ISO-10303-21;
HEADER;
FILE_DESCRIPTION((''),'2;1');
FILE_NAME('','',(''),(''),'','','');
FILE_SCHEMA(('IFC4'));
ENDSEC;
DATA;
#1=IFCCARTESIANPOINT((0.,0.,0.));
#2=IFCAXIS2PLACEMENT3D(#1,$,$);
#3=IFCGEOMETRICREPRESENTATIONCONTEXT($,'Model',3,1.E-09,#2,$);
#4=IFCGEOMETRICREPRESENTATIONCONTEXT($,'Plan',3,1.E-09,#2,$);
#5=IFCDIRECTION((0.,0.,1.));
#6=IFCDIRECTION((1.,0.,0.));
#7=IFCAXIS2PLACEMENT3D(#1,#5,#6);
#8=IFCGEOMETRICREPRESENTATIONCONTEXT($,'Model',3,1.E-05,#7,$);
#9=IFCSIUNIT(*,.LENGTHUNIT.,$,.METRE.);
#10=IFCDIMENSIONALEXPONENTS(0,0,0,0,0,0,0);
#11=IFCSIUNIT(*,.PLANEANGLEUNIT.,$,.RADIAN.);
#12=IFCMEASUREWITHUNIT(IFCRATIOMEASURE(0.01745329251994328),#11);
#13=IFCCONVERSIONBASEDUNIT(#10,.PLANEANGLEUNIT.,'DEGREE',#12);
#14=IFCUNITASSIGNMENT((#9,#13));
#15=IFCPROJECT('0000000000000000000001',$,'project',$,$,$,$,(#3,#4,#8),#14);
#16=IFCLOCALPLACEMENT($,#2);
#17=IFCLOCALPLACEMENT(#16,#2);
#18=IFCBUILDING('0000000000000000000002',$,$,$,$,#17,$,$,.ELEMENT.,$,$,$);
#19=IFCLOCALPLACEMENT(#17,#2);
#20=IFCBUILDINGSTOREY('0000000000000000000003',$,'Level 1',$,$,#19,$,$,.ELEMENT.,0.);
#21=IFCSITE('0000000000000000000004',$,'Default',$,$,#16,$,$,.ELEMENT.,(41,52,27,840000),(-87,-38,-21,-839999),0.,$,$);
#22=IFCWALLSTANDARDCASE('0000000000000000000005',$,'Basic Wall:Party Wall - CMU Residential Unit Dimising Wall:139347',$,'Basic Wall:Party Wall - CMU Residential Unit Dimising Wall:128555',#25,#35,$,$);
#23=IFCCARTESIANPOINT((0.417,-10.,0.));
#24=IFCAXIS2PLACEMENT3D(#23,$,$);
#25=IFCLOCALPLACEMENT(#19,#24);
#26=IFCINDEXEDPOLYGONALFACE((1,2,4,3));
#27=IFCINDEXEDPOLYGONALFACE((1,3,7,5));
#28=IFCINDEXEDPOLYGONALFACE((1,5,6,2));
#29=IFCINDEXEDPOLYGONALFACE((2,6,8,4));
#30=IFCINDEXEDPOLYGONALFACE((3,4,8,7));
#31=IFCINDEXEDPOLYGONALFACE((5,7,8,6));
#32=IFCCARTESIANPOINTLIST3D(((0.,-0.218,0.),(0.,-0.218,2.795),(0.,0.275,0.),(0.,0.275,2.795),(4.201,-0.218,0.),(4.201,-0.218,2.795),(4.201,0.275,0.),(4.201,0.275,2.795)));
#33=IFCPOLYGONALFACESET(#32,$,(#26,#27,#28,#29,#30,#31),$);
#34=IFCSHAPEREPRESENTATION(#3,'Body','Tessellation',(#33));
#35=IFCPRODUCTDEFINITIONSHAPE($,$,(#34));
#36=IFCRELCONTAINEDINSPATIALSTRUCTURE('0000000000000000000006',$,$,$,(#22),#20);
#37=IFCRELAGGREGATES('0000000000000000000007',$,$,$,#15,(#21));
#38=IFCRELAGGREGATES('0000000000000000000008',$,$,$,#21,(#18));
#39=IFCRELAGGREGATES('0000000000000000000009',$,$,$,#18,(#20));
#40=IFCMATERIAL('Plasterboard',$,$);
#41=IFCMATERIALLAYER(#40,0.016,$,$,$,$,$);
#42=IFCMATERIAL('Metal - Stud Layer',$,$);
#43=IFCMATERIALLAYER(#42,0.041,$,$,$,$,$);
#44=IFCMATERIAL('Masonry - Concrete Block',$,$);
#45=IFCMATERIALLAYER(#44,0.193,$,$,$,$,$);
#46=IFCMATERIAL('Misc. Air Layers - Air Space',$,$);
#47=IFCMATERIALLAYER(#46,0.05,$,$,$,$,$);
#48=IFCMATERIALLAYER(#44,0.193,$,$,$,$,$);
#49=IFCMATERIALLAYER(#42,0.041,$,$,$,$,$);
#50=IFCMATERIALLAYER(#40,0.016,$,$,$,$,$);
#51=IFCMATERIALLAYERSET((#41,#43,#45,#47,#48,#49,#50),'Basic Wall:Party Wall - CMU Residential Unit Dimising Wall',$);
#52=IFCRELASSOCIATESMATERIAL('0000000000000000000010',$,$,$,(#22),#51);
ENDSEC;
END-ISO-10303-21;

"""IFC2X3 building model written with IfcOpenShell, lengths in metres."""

from ifc_helpers import new_model, entity, si_unit, converted_unit, frame, frame_2d, origin, origin_with_axes, place, context, project, spatial, polyline, rectangle, extrude, clip, bounded_halfspace, material, layer, layer_set, layer_usage, element, save


model = new_model("IFC2X3")

# Units and contexts
model_context_1 = context("Model", 3, precision=1e-09, world=origin())
plan_context = context("Plan", 3, precision=1e-09, world=origin())
model_context_2 = context("Model", 3, precision=1e-05, world=origin_with_axes())
ifc_project = project(units=[si_unit("LENGTHUNIT", "METRE"), converted_unit("PLANEANGLEUNIT", "DEGREE", entity("IfcRatioMeasure", 0.01745329251994328), si_unit("PLANEANGLEUNIT", "RADIAN"), dimensions=[0, 0, 0, 0, 0, 0, 0])], contexts=[model_context_1, plan_context, model_context_2])

# Site, building, storey
site_placement = place(None, origin())
site = spatial("IfcSite", under=ifc_project, at=site_placement, Name="Default", CompositionType="ELEMENT", RefLatitude=(41, 52, 27, 840000), RefLongitude=(-87, -38, -21, -839999), RefElevation=0.0)
building_placement = place(site_placement, origin())
building = spatial("IfcBuilding", under=site, at=building_placement, CompositionType="ELEMENT")
storey_placement = place(building_placement, origin())
storey = spatial("IfcBuildingStorey", under=building, at=storey_placement, Name="Level 1", CompositionType="ELEMENT", Elevation=0.0)

# Wall
ifc_material_1 = material(Name="Plasterboard")
ifc_layer_1 = layer(ifc_material_1, 0.016)
ifc_material_2 = material(Name="Metal - Stud Layer")
ifc_layer_2 = layer(ifc_material_2, 0.041)
ifc_material_3 = material(Name="Masonry - Concrete Block")
ifc_layer_3 = layer(ifc_material_3, 0.193)
ifc_material_4 = material(Name="Misc. Air Layers - Air Space")
ifc_layer_4 = layer(ifc_material_4, 0.05)
ifc_layer_5 = layer(ifc_material_3, 0.193)
ifc_layer_6 = layer(ifc_material_2, 0.041)
ifc_layer_7 = layer(ifc_material_1, 0.016)
ifc_layer_set_1 = layer_set([ifc_layer_1, ifc_layer_2, ifc_layer_3, ifc_layer_4, ifc_layer_5, ifc_layer_6, ifc_layer_7], Name="Basic Wall:Party Wall - CMU Residential Unit Dimising Wall")
ifc_layer_usage_1 = layer_usage(ifc_layer_set_1, "AXIS2", "NEGATIVE", 0.275)
wall_1_placement = place(storey_placement, frame((0.417, -10.0, 0.0)))
element("IfcWallStandardCase", 1, at=wall_1_placement, inside=storey, material=ifc_layer_usage_1, Name="Basic Wall:Party Wall - CMU Residential Unit Dimising Wall:139347", ObjectType="Basic Wall:Party Wall - CMU Residential Unit Dimising Wall:128555", context=model_context_1, shape_type="Clipping", body=[
    clip(clip(extrude(rectangle(XDim=4.201, YDim=0.55, at=frame_2d((2.1005, 0.0), x_axis=(-1.0, 0.0))), origin(), (0.0, 0.0, 1.0), 2.795), bounded_halfspace(frame((0.0, -0.218, 0.0), z_axis=(0.0, 1.0, 0.0), x_axis=(-1.0, 0.0, 0.0)), True, frame((0.0, -0.218, 0.0), z_axis=(0.0, 1.0, 0.0), x_axis=(-1.0, 0.0, 0.0)), polyline([(0.0, 0.0), (0.0, 2.795), (-4.201, 2.795), (-4.201, 0.0), (0.0, 0.0)]))), bounded_halfspace(frame((4.201, 0.275, 0.0), z_axis=(-1.0, 0.0, 0.0), x_axis=(0.0, -1.0, 0.0)), True, frame((4.201, 0.275, 0.0), z_axis=(-1.0, 0.0, 0.0), x_axis=(0.0, -1.0, 0.0)), polyline([(0.0, 0.0), (0.493, 0.0), (0.493, 2.795), (0.0, 2.795), (0.0, 0.0)]))),
])

save(model, "model.ifc")
